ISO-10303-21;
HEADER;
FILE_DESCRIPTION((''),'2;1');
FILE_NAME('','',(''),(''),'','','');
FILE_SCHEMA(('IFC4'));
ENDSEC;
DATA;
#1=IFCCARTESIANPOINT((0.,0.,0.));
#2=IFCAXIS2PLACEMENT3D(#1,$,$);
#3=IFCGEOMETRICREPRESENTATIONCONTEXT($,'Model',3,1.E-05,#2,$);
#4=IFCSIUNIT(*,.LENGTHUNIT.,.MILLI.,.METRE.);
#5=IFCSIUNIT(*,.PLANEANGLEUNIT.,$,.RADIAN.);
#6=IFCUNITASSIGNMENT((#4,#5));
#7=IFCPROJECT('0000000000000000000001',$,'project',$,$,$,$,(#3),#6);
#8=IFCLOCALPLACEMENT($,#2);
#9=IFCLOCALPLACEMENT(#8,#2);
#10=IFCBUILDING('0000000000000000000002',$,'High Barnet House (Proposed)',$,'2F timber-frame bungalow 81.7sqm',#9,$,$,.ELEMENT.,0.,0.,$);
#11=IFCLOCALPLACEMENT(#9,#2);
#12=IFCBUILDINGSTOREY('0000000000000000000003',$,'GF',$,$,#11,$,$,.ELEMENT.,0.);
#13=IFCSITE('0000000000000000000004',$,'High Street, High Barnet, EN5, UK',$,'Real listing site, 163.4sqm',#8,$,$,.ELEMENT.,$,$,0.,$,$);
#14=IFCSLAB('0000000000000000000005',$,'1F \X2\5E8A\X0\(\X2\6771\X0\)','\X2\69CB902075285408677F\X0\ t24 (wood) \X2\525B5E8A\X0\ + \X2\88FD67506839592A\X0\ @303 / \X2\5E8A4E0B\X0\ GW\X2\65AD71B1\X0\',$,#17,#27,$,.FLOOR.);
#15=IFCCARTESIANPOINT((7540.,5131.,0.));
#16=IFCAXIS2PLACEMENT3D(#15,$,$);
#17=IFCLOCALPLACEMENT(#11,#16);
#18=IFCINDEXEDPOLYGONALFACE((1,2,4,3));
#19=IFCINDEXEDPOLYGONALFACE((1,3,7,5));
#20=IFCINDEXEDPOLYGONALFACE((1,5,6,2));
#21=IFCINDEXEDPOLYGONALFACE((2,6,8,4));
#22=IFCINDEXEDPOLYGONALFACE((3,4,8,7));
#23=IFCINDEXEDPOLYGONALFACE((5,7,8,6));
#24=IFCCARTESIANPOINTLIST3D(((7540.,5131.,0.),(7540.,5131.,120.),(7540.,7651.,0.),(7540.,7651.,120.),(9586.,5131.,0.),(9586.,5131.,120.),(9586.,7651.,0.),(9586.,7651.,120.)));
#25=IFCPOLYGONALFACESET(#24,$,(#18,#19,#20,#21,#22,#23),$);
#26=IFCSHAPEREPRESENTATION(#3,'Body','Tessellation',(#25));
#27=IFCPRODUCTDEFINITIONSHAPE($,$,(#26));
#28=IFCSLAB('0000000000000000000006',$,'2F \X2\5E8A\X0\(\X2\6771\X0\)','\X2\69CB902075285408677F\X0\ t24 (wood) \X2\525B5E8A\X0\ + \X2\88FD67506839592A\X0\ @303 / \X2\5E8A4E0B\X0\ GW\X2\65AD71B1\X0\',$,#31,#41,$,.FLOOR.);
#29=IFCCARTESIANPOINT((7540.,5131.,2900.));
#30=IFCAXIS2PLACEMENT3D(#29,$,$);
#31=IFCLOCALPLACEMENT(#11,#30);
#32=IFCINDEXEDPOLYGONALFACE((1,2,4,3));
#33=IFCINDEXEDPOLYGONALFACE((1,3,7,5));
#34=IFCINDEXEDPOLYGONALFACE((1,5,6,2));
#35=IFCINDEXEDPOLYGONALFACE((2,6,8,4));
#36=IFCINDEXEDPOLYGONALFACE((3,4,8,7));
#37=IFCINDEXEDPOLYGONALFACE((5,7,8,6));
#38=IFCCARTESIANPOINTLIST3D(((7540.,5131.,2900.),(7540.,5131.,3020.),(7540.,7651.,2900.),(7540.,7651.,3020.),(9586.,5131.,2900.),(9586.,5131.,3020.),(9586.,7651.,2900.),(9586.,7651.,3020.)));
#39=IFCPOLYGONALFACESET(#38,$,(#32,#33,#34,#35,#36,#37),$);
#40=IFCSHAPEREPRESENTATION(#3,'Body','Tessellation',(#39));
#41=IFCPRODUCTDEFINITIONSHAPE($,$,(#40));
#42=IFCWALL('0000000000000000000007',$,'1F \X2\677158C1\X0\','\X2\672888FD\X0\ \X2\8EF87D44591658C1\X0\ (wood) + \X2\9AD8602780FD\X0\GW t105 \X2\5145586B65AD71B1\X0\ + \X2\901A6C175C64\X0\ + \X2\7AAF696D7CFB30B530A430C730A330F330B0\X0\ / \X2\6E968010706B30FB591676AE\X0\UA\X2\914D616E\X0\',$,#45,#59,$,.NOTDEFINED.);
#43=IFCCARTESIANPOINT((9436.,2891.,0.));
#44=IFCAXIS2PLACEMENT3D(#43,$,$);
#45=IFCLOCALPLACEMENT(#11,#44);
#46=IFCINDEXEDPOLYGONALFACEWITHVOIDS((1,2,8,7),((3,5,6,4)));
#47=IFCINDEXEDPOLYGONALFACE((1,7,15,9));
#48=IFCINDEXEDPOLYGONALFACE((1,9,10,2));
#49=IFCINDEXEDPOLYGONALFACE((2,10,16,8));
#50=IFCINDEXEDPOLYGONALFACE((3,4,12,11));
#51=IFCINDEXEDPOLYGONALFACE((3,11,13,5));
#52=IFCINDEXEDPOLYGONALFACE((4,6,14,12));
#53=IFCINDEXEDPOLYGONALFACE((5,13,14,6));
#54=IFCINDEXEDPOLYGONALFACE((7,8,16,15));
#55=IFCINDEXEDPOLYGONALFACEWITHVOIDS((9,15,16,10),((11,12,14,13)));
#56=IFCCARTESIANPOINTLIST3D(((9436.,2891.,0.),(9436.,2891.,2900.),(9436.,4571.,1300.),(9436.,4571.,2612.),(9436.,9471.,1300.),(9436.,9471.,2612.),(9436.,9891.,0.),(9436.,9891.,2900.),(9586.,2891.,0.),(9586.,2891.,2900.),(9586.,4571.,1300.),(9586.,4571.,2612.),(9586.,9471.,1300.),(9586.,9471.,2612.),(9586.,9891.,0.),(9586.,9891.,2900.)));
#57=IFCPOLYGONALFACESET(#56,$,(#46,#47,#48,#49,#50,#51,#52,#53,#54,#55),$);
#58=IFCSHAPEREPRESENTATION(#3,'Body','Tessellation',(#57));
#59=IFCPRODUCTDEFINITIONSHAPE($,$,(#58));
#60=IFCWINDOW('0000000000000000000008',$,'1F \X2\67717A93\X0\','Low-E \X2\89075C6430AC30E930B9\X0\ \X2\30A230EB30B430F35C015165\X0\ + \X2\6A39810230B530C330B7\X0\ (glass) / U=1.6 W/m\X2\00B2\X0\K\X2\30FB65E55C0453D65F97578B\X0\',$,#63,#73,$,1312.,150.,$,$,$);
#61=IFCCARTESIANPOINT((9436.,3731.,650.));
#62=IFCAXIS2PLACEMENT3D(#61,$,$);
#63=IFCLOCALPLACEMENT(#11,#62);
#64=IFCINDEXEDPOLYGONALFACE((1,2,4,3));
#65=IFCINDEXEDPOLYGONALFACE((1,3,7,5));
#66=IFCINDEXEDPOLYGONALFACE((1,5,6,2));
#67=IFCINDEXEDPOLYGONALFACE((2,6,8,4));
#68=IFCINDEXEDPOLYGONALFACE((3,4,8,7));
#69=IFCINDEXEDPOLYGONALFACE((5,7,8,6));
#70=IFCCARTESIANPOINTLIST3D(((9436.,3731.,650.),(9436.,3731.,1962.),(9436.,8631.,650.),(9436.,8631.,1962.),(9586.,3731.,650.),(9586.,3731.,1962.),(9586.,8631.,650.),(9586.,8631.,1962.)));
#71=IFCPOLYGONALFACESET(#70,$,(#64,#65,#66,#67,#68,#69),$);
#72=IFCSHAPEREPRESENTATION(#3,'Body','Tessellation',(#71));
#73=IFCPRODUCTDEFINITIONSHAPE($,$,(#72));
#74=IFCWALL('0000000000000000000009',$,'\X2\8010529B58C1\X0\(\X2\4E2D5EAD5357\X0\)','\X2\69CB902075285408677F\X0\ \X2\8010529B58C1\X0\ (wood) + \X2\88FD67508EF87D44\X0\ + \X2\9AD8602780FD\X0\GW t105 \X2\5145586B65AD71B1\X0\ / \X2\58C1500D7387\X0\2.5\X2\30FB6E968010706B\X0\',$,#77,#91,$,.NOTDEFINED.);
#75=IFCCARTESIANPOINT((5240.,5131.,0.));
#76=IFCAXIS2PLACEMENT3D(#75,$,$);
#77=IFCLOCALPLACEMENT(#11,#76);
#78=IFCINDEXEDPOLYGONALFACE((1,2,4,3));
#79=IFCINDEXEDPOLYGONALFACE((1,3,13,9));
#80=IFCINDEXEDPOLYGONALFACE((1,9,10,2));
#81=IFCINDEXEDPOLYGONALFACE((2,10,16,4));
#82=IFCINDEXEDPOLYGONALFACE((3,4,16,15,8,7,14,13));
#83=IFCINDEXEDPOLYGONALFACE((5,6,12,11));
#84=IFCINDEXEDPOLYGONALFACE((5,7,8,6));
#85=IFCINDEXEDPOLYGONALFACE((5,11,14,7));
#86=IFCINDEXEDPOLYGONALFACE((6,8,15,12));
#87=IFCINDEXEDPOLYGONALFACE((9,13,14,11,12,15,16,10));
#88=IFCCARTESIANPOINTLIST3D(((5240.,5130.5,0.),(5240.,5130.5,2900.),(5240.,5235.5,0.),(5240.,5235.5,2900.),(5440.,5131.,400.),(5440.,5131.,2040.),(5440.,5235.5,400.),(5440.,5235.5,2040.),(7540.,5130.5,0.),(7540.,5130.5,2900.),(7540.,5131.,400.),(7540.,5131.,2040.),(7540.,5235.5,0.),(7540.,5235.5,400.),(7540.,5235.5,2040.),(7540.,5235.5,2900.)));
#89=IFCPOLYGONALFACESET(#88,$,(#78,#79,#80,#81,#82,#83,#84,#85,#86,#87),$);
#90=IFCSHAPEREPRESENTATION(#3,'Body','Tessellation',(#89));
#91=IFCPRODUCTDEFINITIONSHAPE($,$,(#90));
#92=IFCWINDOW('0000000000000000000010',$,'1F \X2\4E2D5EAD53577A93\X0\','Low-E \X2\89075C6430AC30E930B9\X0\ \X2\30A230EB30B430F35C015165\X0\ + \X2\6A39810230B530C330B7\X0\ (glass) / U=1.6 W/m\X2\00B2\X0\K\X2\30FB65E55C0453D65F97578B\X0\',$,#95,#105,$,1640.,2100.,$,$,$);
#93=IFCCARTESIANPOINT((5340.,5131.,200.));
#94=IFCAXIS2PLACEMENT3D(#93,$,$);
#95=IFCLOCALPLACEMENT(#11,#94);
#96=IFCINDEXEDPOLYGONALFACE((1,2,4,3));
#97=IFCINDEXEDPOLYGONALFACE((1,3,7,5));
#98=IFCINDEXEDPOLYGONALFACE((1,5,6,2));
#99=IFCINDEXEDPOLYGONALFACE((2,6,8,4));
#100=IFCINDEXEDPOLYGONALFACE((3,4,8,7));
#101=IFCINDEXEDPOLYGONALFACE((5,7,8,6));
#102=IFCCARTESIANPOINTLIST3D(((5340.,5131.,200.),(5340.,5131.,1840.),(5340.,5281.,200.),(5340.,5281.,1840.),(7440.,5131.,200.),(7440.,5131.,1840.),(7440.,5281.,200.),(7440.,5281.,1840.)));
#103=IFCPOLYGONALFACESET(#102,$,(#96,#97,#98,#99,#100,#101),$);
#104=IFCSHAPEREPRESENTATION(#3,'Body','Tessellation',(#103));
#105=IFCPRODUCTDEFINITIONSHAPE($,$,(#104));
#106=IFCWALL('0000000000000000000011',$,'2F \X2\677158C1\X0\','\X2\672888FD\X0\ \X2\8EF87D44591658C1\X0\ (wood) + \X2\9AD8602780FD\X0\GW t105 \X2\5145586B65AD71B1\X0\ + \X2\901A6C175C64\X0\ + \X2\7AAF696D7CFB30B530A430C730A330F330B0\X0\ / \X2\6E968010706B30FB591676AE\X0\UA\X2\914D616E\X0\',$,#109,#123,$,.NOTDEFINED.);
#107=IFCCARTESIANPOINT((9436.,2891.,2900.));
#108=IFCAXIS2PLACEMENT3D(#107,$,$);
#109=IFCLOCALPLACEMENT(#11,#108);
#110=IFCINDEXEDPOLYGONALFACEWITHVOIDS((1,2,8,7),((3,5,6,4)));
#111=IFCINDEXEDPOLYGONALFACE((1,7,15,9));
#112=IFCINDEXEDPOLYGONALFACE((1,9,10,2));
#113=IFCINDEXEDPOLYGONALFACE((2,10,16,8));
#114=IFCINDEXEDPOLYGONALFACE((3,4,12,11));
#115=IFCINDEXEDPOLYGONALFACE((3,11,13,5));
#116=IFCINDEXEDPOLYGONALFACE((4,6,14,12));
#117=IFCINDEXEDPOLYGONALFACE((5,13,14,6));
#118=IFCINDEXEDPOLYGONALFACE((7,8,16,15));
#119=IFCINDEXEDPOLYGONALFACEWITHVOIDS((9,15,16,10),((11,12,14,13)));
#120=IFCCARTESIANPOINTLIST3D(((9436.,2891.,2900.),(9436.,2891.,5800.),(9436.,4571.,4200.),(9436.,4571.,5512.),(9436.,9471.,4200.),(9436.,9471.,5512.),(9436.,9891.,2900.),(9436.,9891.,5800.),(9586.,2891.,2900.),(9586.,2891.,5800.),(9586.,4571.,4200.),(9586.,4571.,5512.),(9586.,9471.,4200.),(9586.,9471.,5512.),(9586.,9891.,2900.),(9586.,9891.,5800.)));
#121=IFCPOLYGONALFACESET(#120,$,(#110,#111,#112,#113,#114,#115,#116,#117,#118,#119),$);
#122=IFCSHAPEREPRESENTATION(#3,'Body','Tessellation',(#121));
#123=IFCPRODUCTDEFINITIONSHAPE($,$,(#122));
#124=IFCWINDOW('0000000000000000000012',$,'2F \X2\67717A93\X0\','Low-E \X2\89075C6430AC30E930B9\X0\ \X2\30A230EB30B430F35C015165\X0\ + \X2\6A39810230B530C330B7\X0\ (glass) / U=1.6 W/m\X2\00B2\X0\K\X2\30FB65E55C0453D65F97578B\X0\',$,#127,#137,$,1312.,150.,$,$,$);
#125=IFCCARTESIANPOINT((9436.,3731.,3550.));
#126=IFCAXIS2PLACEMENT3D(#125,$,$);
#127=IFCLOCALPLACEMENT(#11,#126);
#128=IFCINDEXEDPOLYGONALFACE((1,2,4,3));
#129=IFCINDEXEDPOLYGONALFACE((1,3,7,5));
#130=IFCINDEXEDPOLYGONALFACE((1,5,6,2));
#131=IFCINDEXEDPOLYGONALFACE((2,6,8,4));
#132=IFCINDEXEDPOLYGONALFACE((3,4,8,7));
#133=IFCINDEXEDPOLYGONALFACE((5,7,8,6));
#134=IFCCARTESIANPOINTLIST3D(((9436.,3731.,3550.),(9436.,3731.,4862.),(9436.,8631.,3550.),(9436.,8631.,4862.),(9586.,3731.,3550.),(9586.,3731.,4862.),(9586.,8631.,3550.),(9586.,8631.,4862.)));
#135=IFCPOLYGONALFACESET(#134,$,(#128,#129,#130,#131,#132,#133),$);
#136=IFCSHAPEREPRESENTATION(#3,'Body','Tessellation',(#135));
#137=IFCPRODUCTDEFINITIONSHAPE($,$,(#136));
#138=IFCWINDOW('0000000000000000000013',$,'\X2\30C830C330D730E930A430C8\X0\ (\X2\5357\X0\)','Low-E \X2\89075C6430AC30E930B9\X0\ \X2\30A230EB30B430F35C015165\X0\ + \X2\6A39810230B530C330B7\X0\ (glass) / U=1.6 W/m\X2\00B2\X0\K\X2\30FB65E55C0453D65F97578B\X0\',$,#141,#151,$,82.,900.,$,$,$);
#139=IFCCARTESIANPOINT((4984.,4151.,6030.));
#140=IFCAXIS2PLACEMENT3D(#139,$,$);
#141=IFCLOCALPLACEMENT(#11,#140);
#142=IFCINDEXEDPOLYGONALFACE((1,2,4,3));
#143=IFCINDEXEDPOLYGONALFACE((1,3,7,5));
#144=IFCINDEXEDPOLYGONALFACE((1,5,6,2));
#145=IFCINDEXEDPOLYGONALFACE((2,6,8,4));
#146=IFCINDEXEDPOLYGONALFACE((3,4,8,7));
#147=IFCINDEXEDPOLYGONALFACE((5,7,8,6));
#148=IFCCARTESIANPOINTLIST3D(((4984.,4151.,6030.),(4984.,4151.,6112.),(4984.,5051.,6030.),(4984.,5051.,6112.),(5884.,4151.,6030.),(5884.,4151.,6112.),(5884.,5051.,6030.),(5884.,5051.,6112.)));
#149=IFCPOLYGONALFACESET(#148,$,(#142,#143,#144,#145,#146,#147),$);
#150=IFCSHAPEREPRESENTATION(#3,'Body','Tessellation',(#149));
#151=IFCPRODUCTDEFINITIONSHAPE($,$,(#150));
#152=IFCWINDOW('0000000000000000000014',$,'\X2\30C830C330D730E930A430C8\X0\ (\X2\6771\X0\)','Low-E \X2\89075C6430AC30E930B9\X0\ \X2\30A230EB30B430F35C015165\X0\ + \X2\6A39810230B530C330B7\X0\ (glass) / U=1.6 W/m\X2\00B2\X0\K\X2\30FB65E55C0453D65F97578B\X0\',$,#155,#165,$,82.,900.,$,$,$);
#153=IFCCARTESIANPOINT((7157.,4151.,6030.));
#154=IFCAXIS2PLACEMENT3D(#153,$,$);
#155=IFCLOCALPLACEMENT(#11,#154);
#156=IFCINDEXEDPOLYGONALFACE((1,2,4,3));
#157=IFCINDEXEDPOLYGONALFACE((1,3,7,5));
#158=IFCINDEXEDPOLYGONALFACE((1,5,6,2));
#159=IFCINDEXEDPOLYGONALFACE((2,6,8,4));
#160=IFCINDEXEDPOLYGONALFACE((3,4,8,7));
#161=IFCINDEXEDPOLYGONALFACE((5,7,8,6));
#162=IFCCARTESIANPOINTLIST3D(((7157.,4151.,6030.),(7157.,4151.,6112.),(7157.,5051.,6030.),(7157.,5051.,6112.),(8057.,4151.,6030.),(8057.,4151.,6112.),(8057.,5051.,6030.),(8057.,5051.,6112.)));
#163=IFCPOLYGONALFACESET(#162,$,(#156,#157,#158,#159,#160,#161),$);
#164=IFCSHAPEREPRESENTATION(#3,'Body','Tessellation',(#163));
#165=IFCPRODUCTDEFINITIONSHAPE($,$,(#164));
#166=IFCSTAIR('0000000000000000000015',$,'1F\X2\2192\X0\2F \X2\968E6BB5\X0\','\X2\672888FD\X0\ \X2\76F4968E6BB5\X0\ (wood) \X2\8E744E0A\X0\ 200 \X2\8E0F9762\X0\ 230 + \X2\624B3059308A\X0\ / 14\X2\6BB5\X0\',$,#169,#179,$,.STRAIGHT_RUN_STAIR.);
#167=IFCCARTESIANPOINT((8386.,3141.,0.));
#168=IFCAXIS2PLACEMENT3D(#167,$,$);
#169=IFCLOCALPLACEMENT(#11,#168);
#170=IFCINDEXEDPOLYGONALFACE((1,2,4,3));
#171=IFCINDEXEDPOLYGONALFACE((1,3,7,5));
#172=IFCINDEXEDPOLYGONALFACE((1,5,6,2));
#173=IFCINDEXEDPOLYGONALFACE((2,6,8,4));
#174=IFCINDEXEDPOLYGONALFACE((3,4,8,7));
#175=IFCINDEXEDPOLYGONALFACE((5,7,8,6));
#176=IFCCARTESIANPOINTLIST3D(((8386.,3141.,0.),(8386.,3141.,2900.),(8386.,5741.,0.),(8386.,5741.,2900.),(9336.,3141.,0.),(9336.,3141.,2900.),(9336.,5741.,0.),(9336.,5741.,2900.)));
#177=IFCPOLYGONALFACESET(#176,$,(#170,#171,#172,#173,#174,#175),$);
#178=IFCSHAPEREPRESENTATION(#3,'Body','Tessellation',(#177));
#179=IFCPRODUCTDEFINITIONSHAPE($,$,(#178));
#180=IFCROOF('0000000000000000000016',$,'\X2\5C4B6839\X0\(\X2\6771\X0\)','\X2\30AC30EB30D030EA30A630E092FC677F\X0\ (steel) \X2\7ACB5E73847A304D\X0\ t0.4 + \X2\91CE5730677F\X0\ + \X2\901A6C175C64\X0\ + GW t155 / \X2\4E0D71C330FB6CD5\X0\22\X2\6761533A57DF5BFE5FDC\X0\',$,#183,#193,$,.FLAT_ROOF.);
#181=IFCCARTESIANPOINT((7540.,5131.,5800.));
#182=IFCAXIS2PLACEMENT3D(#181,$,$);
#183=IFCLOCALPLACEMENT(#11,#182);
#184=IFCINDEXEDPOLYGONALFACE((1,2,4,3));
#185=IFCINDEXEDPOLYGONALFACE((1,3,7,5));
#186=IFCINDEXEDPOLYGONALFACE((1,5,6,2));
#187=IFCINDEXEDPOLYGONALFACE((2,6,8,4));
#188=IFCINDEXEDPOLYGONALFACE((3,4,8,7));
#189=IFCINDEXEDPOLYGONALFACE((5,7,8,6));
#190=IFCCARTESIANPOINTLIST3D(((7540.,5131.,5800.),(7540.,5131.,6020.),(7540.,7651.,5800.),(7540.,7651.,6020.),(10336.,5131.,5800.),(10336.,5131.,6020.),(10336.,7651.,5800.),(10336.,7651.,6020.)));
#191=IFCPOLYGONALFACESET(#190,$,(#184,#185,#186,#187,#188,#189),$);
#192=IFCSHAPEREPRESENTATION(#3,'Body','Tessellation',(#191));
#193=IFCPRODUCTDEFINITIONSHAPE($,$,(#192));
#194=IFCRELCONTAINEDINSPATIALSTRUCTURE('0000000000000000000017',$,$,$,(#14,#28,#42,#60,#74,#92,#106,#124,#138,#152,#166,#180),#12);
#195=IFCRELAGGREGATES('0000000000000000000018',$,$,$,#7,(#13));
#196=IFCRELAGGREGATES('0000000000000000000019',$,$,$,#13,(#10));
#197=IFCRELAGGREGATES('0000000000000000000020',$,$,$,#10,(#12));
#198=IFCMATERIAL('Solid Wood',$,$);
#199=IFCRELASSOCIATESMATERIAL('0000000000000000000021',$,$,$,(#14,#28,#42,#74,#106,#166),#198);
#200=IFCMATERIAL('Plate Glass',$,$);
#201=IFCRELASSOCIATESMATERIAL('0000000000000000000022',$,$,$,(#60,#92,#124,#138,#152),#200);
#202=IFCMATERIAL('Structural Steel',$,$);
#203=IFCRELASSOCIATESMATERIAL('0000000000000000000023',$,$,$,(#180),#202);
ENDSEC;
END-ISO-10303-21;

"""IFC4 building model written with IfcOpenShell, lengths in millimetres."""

from ifc_helpers import new_model, si_unit, frame, frame_2d, origin, place, context, project, spatial, rectangle, extrude, material, element, fill, save


model = new_model("IFC4")

# Units and contexts
model_context = context("Model", 3, precision=1e-05, world=origin())
ifc_project = project(units=[si_unit("LENGTHUNIT", "METRE", prefix="MILLI"), si_unit("PLANEANGLEUNIT", "RADIAN")], contexts=[model_context])

# Site, building, storey
site_placement = place(None, origin())
site = spatial("IfcSite", under=ifc_project, at=site_placement, Name="High Street, High Barnet, EN5, UK", ObjectType="Real listing site, 163.4sqm", CompositionType="ELEMENT", RefElevation=0.0)
building_placement = place(site_placement, origin())
building = spatial("IfcBuilding", under=site, at=building_placement, Name="High Barnet House (Proposed)", ObjectType="2F timber-frame bungalow 81.7sqm", CompositionType="ELEMENT", ElevationOfRefHeight=0.0, ElevationOfTerrain=0.0)
storey_placement = place(building_placement, origin())
storey = spatial("IfcBuildingStorey", under=building, at=storey_placement, Name="GF", CompositionType="ELEMENT", Elevation=0.0)

# Slabs
ifc_material_1 = material(Name="Solid Wood")
slab_1_placement = place(storey_placement, frame((7540.0, 5131.0, 0.0)))
element("IfcSlab", 1, at=slab_1_placement, inside=storey, material=ifc_material_1, Name="1F 床(東)", Description="構造用合板 t24 (wood) 剛床 + 製材根太 @303 / 床下 GW断熱", PredefinedType="FLOOR", context=model_context, shape_type="SweptSolid", body=[
    extrude(rectangle(XDim=2046.0, YDim=2520.0, at=frame_2d((1023.0, 1260.0))), frame((7540.0, 5131.0, 0.0)), (0.0, 0.0, 1.0), 120.0),
])
slab_2_placement = place(storey_placement, frame((7540.0, 5131.0, 2900.0)))
element("IfcSlab", 2, at=slab_2_placement, inside=storey, material=ifc_material_1, Name="2F 床(東)", Description="構造用合板 t24 (wood) 剛床 + 製材根太 @303 / 床下 GW断熱", PredefinedType="FLOOR", context=model_context, shape_type="SweptSolid", body=[
    extrude(rectangle(XDim=2046.0, YDim=2520.0, at=frame_2d((1023.0, 1260.0))), frame((7540.0, 5131.0, 2900.0)), (0.0, 0.0, 1.0), 120.0),
])

# Walls, openings, windows
wall_1_placement = place(storey_placement, frame((9436.0, 2891.0, 0.0)))
wall_1 = element("IfcWall", 3, at=wall_1_placement, inside=storey, material=ifc_material_1, Name="1F 東壁", Description="木製 軸組外壁 (wood) + 高性能GW t105 充填断熱 + 通気層 + 窯業系サイディング / 準耐火・外皮UA配慮", PredefinedType="NOTDEFINED", context=model_context, shape_type="SweptSolid", body=[
    extrude(rectangle(XDim=150.0, YDim=7000.0, at=frame_2d((75.0, 3500.0))), frame((9436.0, 2891.0, 0.0)), (0.0, 0.0, 1.0), 2900.0),
])
opening_1_placement = place(storey_placement, frame((9436.0, 3731.0, 650.0)))
opening_1 = element("IfcOpeningElement", 4, at=opening_1_placement, cuts=wall_1, PredefinedType="NOTDEFINED", context=model_context, shape_type="SweptSolid", body=[
    extrude(rectangle(XDim=150.0, YDim=4900.0, at=frame_2d((75.0, 2450.0))), frame((9436.0, 3731.0, 650.0)), (0.0, 0.0, 1.0), 1312.0),
])
ifc_material_2 = material(Name="Plate Glass")
window_1_placement = place(storey_placement, frame((9436.0, 3731.0, 650.0)))
window_1 = element("IfcWindow", 5, at=window_1_placement, inside=storey, material=ifc_material_2, Name="1F 東窓", Description="Low-E 複層ガラス アルゴン封入 + 樹脂サッシ (glass) / U=1.6 W/m²K・日射取得型", OverallHeight=1312.0, OverallWidth=150.0, context=model_context, shape_type="SweptSolid", body=[
    extrude(rectangle(XDim=150.0, YDim=4900.0, at=frame_2d((75.0, 2450.0))), frame((9436.0, 3731.0, 650.0)), (0.0, 0.0, 1.0), 1312.0),
])
fill(opening_1, window_1)
wall_2_placement = place(storey_placement, frame((5240.0, 5131.0, 0.0)))
wall_2 = element("IfcWall", 6, at=wall_2_placement, inside=storey, material=ifc_material_1, Name="耐力壁(中庭南)", Description="構造用合板 耐力壁 (wood) + 製材軸組 + 高性能GW t105 充填断熱 / 壁倍率2.5・準耐火", PredefinedType="NOTDEFINED", context=model_context, shape_type="SweptSolid", body=[
    extrude(rectangle(XDim=2300.0, YDim=105.0, at=frame_2d((1150.0, 52.0))), frame((5240.0, 5131.0, 0.0)), (0.0, 0.0, 1.0), 2900.0),
])
opening_2_placement = place(storey_placement, frame((5340.0, 5131.0, 200.0)))
opening_2 = element("IfcOpeningElement", 7, at=opening_2_placement, cuts=wall_2, PredefinedType="NOTDEFINED", context=model_context, shape_type="SweptSolid", body=[
    extrude(rectangle(XDim=2100.0, YDim=150.0, at=frame_2d((1050.0, 75.0))), frame((5340.0, 5131.0, 200.0)), (0.0, 0.0, 1.0), 1640.0),
])
window_2_placement = place(storey_placement, frame((5340.0, 5131.0, 200.0)))
window_2 = element("IfcWindow", 8, at=window_2_placement, inside=storey, material=ifc_material_2, Name="1F 中庭南窓", Description="Low-E 複層ガラス アルゴン封入 + 樹脂サッシ (glass) / U=1.6 W/m²K・日射取得型", OverallHeight=1640.0, OverallWidth=2100.0, context=model_context, shape_type="SweptSolid", body=[
    extrude(rectangle(XDim=2100.0, YDim=150.0, at=frame_2d((1050.0, 75.0))), frame((5340.0, 5131.0, 200.0)), (0.0, 0.0, 1.0), 1640.0),
])
fill(opening_2, window_2)

# Wall, opening, window
wall_3_placement = place(storey_placement, frame((9436.0, 2891.0, 2900.0)))
wall_3 = element("IfcWall", 9, at=wall_3_placement, inside=storey, material=ifc_material_1, Name="2F 東壁", Description="木製 軸組外壁 (wood) + 高性能GW t105 充填断熱 + 通気層 + 窯業系サイディング / 準耐火・外皮UA配慮", PredefinedType="NOTDEFINED", context=model_context, shape_type="SweptSolid", body=[
    extrude(rectangle(XDim=150.0, YDim=7000.0, at=frame_2d((75.0, 3500.0))), frame((9436.0, 2891.0, 2900.0)), (0.0, 0.0, 1.0), 2900.0),
])
opening_3_placement = place(storey_placement, frame((9436.0, 3731.0, 3550.0)))
opening_3 = element("IfcOpeningElement", 10, at=opening_3_placement, cuts=wall_3, PredefinedType="NOTDEFINED", context=model_context, shape_type="SweptSolid", body=[
    extrude(rectangle(XDim=150.0, YDim=4900.0, at=frame_2d((75.0, 2450.0))), frame((9436.0, 3731.0, 3550.0)), (0.0, 0.0, 1.0), 1312.0),
])
window_3_placement = place(storey_placement, frame((9436.0, 3731.0, 3550.0)))
window_3 = element("IfcWindow", 11, at=window_3_placement, inside=storey, material=ifc_material_2, Name="2F 東窓", Description="Low-E 複層ガラス アルゴン封入 + 樹脂サッシ (glass) / U=1.6 W/m²K・日射取得型", OverallHeight=1312.0, OverallWidth=150.0, context=model_context, shape_type="SweptSolid", body=[
    extrude(rectangle(XDim=150.0, YDim=4900.0, at=frame_2d((75.0, 2450.0))), frame((9436.0, 3731.0, 3550.0)), (0.0, 0.0, 1.0), 1312.0),
])
fill(opening_3, window_3)

# Windows
window_4_placement = place(storey_placement, frame((4984.0, 4151.0, 6030.0)))
element("IfcWindow", 12, at=window_4_placement, inside=storey, material=ifc_material_2, Name="トップライト (南)", Description="Low-E 複層ガラス アルゴン封入 + 樹脂サッシ (glass) / U=1.6 W/m²K・日射取得型", OverallHeight=82.0, OverallWidth=900.0, context=model_context, shape_type="SweptSolid", body=[
    extrude(rectangle(XDim=900.0, YDim=900.0, at=frame_2d((450.0, 450.0))), frame((4984.0, 4151.0, 6030.0)), (0.0, 0.0, 1.0), 82.0),
])
window_5_placement = place(storey_placement, frame((7157.0, 4151.0, 6030.0)))
element("IfcWindow", 13, at=window_5_placement, inside=storey, material=ifc_material_2, Name="トップライト (東)", Description="Low-E 複層ガラス アルゴン封入 + 樹脂サッシ (glass) / U=1.6 W/m²K・日射取得型", OverallHeight=82.0, OverallWidth=900.0, context=model_context, shape_type="SweptSolid", body=[
    extrude(rectangle(XDim=900.0, YDim=900.0, at=frame_2d((450.0, 450.0))), frame((7157.0, 4151.0, 6030.0)), (0.0, 0.0, 1.0), 82.0),
])

# Stair
stair_placement = place(storey_placement, frame((8386.0, 3141.0, 0.0)))
element("IfcStair", 14, at=stair_placement, inside=storey, material=ifc_material_1, Name="1F→2F 階段", Description="木製 直階段 (wood) 蹴上 200 踏面 230 + 手すり / 14段", PredefinedType="STRAIGHT_RUN_STAIR", context=model_context, shape_type="SweptSolid", body=[
    extrude(rectangle(XDim=950.0, YDim=2600.0, at=frame_2d((475.0, 1300.0))), frame((8386.0, 3141.0, 0.0)), (0.0, 0.0, 1.0), 2900.0),
])

# Roof
ifc_material_3 = material(Name="Structural Steel")
roof_placement = place(storey_placement, frame((7540.0, 5131.0, 5800.0)))
element("IfcRoof", 15, at=roof_placement, inside=storey, material=ifc_material_3, Name="屋根(東)", Description="ガルバリウム鋼板 (steel) 立平葺き t0.4 + 野地板 + 通気層 + GW t155 / 不燃・法22条区域対応", PredefinedType="FLAT_ROOF", context=model_context, shape_type="SweptSolid", body=[
    extrude(rectangle(XDim=2796.0, YDim=2520.0, at=frame_2d((1398.0, 1260.0))), frame((7540.0, 5131.0, 5800.0)), (0.0, 0.0, 1.0), 220.0),
])

save(model, "model.ifc")
